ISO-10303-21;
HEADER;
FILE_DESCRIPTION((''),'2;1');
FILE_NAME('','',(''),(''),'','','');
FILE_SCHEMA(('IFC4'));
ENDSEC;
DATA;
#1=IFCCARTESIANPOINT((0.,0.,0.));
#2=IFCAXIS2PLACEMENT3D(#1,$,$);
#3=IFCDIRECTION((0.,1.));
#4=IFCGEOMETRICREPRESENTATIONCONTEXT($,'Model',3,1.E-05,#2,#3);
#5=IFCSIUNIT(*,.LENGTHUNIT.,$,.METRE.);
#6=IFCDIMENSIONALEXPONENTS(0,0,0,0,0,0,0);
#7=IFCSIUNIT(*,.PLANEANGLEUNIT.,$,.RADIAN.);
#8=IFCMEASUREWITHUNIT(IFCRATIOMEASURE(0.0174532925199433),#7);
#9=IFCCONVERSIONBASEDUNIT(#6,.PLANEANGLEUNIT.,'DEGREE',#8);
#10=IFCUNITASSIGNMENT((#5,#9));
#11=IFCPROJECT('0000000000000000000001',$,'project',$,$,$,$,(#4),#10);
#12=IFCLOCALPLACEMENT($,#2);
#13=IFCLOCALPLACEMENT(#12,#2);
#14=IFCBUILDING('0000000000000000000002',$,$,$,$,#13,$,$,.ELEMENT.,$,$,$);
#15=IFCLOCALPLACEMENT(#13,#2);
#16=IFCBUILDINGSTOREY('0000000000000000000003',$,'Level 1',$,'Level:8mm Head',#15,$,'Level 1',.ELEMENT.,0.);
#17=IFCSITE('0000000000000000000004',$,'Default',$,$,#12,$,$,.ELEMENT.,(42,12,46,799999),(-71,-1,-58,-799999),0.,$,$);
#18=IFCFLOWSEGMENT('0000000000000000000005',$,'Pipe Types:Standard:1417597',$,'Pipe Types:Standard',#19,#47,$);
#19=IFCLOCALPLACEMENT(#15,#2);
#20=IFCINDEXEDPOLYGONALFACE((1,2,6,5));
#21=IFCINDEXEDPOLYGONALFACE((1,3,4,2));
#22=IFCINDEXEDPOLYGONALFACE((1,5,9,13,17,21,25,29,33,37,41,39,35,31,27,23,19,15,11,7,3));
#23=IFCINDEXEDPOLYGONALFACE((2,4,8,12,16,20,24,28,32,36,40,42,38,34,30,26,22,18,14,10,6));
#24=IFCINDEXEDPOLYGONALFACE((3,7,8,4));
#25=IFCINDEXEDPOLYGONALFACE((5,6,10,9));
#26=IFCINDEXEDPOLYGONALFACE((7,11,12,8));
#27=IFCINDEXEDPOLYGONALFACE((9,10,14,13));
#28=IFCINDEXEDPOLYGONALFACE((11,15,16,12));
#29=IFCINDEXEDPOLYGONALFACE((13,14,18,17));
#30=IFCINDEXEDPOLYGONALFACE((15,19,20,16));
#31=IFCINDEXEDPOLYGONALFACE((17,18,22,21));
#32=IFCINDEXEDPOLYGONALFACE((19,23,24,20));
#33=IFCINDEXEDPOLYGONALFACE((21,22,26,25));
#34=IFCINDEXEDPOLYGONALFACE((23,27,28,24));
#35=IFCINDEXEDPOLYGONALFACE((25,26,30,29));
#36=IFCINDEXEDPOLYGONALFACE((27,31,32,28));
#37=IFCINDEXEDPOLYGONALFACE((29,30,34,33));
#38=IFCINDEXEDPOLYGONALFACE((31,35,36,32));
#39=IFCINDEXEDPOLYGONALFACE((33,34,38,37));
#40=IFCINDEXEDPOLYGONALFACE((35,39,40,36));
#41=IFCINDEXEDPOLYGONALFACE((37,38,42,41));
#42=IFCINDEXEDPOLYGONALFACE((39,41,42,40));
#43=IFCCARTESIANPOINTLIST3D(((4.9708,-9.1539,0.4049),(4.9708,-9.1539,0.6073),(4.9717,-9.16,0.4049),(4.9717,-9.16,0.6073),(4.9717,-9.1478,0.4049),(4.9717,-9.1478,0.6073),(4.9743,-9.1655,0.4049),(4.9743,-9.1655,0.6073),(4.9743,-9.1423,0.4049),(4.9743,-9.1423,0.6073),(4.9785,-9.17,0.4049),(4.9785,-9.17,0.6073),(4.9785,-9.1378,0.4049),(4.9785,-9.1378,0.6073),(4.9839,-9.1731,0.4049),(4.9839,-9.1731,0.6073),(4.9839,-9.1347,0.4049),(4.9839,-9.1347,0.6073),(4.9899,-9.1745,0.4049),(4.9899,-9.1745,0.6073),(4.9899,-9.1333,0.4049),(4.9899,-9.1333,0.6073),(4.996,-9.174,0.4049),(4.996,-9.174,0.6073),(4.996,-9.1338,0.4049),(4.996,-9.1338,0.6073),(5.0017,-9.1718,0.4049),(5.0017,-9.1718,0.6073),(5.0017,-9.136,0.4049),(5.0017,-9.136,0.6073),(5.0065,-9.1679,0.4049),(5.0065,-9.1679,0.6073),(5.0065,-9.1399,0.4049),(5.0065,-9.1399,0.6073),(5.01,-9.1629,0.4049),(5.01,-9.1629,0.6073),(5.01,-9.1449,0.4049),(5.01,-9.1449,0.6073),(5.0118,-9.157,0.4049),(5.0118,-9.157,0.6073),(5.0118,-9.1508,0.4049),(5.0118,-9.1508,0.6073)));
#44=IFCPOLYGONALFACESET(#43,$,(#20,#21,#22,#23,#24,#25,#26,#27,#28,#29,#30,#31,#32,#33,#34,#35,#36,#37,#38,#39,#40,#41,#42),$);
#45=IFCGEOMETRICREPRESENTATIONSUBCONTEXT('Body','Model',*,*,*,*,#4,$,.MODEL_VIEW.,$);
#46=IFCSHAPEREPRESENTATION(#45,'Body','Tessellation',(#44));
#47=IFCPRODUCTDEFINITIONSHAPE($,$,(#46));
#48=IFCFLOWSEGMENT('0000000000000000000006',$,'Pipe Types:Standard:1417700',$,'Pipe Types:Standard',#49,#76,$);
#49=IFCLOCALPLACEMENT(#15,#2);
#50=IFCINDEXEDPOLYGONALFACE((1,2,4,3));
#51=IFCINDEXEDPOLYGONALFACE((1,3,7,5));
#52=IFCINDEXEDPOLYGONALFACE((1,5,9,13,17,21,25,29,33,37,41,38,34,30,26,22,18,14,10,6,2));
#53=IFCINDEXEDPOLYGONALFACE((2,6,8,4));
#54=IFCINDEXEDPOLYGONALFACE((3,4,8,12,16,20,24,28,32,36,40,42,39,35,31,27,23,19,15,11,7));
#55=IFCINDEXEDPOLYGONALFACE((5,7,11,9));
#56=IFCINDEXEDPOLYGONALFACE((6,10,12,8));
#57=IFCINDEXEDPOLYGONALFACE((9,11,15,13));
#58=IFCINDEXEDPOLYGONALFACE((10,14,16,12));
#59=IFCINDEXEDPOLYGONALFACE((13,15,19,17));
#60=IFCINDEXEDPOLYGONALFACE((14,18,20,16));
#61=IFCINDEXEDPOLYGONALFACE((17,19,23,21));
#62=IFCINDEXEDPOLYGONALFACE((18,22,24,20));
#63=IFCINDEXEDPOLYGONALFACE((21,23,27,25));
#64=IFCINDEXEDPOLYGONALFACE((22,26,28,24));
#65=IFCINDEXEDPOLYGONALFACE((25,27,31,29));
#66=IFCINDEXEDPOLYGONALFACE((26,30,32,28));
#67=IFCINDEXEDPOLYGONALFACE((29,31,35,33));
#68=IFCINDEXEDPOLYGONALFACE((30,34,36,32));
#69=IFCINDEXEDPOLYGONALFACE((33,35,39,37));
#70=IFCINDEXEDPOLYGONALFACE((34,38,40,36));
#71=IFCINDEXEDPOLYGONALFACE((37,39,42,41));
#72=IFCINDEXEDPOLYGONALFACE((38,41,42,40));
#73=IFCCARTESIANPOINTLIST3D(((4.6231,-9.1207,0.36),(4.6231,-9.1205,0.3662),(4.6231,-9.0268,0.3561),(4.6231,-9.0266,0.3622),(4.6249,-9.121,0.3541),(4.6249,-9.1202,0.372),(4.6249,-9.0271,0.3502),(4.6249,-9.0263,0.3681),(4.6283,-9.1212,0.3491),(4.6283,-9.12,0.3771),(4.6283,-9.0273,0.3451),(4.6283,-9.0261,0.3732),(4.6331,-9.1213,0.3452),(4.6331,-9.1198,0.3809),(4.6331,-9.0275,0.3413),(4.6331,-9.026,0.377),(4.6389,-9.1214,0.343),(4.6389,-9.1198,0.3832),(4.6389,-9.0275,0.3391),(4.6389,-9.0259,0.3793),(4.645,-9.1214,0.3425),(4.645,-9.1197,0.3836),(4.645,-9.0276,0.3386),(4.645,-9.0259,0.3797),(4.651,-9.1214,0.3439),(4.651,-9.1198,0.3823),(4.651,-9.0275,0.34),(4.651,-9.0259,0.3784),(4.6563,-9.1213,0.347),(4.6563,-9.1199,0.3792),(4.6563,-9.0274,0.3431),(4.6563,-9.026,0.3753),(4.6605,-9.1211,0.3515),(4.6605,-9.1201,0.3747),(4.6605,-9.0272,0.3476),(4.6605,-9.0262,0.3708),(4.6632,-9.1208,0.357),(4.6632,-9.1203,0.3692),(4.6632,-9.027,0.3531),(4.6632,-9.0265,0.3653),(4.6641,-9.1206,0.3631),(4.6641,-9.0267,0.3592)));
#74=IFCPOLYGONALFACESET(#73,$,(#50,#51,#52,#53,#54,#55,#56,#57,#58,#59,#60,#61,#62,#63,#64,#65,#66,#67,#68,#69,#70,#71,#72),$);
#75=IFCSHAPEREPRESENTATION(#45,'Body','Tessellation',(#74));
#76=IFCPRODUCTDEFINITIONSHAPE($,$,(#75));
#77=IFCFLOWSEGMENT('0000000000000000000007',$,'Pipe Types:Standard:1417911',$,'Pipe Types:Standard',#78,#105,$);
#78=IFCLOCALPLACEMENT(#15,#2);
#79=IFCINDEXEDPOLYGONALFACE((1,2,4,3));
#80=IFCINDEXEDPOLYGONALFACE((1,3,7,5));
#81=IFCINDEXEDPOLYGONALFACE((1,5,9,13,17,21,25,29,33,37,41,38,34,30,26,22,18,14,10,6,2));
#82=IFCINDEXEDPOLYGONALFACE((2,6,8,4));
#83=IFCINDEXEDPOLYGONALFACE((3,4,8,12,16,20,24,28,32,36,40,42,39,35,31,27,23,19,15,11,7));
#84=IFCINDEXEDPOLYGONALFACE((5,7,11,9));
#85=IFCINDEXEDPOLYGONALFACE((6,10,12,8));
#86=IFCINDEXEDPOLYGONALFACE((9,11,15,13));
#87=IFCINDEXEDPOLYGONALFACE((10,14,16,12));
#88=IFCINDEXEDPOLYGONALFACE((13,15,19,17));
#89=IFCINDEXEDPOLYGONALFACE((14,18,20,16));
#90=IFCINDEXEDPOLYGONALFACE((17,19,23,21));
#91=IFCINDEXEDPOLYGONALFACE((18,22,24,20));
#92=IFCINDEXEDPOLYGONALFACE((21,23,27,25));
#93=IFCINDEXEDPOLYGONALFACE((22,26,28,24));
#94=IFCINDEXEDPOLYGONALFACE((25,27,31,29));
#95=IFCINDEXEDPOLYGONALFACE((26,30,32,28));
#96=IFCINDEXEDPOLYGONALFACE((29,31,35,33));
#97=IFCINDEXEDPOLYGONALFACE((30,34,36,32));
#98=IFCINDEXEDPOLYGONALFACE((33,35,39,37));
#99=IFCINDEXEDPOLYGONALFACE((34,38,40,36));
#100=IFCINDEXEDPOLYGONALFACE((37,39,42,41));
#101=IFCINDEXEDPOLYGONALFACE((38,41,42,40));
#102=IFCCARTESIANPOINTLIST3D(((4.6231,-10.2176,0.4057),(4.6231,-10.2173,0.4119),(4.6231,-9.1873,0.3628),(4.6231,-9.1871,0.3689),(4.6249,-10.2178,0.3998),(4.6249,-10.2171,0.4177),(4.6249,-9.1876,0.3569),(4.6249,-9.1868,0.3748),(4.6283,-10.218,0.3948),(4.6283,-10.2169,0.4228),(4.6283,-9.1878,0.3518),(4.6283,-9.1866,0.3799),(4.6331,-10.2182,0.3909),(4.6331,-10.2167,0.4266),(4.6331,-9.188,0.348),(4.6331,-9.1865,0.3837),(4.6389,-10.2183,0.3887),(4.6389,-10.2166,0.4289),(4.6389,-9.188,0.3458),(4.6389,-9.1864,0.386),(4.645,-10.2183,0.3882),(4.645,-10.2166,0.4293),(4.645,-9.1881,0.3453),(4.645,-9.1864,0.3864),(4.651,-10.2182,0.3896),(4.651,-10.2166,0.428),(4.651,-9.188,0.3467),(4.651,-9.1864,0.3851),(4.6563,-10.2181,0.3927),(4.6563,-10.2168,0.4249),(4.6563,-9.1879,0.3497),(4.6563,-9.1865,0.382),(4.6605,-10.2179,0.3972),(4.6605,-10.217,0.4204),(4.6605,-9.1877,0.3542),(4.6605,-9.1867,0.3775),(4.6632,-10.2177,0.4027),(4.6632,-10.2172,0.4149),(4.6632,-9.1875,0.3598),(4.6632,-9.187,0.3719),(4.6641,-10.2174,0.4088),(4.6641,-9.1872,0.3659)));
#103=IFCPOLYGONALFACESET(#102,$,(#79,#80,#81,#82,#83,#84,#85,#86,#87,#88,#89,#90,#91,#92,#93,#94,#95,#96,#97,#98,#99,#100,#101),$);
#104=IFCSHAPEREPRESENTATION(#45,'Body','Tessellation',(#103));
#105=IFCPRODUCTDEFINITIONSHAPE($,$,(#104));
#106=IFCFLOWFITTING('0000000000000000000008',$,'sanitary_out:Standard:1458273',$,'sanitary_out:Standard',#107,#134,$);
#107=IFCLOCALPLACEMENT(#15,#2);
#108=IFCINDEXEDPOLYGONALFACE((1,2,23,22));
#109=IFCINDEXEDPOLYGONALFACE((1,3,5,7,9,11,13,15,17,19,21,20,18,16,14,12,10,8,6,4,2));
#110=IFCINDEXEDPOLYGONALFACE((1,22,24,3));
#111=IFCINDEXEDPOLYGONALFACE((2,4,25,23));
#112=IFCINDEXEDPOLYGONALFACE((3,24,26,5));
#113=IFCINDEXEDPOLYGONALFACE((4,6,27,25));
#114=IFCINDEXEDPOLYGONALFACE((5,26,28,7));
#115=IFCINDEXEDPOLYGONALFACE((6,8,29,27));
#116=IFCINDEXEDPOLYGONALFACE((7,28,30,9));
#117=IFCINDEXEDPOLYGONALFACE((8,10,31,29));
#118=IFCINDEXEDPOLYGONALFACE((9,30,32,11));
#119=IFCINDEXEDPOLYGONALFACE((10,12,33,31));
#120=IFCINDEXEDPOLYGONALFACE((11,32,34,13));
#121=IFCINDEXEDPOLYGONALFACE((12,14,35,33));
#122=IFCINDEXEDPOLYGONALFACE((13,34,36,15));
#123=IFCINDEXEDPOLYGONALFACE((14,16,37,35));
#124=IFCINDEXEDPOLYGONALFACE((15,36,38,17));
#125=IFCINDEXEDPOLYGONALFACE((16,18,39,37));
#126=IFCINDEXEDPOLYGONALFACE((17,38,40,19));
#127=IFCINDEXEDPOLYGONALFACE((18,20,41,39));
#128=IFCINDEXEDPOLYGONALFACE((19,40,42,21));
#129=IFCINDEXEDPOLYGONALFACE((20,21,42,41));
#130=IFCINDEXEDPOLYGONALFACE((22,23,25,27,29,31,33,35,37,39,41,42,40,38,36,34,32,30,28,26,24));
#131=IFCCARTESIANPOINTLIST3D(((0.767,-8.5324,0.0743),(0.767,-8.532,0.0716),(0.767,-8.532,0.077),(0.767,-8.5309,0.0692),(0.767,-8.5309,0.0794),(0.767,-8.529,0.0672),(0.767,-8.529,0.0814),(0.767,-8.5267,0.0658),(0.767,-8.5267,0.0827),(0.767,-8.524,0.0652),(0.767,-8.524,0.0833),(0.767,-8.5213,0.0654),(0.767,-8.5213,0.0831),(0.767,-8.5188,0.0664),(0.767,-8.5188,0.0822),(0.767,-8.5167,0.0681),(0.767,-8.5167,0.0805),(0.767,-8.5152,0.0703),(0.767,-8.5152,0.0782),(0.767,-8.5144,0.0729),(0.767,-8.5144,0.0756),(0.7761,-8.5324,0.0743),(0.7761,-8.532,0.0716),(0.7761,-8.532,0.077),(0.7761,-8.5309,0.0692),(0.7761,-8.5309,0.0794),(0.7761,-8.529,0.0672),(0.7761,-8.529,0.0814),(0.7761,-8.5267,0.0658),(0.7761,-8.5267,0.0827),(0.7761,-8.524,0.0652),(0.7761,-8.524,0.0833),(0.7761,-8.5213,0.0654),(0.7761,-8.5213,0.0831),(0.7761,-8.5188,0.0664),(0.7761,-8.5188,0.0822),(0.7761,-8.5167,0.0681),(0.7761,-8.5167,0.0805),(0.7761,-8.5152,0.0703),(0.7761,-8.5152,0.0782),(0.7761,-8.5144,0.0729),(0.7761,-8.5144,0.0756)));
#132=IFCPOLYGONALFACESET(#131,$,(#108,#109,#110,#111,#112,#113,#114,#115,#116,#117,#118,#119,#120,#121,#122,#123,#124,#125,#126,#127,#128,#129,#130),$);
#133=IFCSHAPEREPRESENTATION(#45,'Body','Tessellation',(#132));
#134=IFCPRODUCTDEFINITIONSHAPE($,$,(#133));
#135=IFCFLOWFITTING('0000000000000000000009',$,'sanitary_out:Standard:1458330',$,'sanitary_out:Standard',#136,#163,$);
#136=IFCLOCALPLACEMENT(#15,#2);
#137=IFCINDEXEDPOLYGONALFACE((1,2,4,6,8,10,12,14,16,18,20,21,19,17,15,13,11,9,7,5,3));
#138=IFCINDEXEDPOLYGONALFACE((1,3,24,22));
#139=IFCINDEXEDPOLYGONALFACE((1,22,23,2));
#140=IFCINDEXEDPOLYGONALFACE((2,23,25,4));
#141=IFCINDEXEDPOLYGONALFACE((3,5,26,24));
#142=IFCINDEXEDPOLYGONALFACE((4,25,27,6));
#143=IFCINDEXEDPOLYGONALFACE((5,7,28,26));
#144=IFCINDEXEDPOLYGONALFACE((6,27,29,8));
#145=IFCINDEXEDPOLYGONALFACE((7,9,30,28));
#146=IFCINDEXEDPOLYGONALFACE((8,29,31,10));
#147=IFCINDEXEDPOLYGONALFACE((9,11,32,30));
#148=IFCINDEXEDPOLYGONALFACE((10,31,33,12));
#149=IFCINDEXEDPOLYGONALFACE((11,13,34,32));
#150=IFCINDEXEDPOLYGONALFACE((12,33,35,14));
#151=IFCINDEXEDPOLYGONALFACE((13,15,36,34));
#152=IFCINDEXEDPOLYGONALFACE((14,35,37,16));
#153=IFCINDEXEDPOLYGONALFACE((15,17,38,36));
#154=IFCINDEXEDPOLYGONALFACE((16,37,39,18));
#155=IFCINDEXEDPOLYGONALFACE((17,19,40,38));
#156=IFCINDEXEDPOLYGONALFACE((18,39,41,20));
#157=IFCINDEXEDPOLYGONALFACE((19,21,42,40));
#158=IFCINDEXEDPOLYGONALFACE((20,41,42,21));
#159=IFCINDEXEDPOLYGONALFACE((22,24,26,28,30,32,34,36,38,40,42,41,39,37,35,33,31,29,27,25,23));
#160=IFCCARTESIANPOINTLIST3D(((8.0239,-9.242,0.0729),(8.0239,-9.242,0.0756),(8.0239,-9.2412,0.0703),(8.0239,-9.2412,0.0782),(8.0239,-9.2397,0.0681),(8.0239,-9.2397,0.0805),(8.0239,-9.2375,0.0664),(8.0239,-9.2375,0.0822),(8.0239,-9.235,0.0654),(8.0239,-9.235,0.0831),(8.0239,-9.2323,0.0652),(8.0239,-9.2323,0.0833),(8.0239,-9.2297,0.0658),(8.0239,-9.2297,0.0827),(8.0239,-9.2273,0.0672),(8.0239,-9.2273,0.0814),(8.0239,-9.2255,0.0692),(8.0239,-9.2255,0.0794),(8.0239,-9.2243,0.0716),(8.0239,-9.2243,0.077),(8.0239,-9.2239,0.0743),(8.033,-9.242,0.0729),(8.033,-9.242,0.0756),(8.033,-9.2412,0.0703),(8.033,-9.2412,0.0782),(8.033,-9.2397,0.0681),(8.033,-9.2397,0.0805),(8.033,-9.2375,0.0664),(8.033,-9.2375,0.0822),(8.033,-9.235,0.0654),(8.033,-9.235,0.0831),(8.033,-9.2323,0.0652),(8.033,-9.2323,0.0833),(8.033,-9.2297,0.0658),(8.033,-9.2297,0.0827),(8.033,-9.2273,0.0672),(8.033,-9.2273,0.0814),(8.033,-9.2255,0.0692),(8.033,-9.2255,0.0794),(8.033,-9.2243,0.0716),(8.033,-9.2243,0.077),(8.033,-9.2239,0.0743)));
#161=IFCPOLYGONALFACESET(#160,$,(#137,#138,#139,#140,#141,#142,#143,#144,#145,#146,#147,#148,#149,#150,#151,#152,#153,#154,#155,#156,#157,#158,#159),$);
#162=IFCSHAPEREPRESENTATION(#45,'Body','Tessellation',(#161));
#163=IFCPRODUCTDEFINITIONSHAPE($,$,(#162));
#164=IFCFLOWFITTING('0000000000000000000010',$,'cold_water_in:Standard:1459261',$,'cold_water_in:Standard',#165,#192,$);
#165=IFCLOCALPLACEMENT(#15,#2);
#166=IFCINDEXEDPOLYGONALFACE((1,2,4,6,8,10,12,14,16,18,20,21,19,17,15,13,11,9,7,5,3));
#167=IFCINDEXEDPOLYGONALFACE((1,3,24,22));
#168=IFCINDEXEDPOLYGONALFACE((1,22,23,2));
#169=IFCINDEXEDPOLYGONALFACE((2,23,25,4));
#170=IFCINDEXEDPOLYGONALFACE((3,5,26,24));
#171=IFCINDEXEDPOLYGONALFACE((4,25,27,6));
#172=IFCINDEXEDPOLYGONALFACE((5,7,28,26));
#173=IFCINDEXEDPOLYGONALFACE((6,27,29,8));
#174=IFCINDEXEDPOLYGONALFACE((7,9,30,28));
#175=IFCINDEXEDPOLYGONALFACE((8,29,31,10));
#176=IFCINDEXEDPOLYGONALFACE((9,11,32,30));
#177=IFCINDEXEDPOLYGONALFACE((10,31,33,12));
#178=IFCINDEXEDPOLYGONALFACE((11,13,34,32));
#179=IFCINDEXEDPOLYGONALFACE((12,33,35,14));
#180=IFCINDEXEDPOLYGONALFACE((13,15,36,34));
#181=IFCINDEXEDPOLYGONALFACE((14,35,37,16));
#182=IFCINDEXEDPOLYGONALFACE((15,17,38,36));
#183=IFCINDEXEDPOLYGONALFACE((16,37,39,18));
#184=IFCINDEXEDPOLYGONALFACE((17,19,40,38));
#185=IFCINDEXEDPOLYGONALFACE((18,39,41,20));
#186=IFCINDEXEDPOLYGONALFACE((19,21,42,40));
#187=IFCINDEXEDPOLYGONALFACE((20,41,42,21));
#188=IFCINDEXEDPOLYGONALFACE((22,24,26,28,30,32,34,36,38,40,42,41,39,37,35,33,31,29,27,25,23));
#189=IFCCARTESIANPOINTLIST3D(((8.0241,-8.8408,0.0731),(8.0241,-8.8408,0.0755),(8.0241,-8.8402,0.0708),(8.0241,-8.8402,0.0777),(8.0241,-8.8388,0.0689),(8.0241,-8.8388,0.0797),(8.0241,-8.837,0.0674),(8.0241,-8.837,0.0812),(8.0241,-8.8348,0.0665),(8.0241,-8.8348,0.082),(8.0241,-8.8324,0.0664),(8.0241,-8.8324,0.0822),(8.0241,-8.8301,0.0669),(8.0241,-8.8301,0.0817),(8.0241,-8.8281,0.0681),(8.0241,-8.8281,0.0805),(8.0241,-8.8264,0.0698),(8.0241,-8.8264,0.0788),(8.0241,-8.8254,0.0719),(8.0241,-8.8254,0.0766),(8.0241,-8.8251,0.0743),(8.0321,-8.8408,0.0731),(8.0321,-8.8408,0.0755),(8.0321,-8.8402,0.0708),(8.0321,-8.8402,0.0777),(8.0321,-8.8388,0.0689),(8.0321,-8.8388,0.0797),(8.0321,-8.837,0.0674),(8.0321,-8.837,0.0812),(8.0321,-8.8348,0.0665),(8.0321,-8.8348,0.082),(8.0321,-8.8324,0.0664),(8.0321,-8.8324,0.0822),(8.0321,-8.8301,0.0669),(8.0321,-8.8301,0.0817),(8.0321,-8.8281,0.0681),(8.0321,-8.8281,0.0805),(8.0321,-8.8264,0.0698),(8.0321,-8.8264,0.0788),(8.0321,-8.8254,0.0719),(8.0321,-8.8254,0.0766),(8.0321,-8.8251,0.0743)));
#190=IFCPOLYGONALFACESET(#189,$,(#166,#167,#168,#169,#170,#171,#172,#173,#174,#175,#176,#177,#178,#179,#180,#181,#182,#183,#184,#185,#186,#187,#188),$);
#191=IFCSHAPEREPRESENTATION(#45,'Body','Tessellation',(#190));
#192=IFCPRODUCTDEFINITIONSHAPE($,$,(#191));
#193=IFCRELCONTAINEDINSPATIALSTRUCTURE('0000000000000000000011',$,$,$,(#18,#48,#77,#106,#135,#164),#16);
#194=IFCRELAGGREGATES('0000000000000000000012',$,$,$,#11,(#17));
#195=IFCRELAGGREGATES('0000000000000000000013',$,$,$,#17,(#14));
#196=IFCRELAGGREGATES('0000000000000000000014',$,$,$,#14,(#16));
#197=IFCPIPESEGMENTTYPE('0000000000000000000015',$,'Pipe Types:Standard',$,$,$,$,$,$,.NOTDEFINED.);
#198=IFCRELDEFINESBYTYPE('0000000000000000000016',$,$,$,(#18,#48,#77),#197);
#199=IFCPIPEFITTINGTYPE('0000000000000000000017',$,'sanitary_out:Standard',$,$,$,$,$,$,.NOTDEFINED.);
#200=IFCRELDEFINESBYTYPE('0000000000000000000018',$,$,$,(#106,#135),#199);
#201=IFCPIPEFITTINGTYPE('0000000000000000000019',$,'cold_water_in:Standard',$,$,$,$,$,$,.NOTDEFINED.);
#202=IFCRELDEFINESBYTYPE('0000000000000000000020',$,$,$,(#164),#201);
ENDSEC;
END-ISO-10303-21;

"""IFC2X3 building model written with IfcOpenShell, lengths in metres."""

from ifc_helpers import new_model, entity, si_unit, converted_unit, direction, frame, frame_2d, origin, origin_2d_with_axis, place, context, subcontext, project, spatial, circle, extrude, source, transform, mapped, type_object, type_shapes, element, save


model = new_model("IFC2X3")

# Units and contexts
model_context = context("Model", 3, precision=1e-05, world=origin(), true_north=direction((0.0, 1.0)))
body_context = subcontext(model_context, "Body", "Model", "MODEL_VIEW")
ifc_project = project(units=[si_unit("LENGTHUNIT", "METRE"), converted_unit("PLANEANGLEUNIT", "DEGREE", entity("IfcRatioMeasure", 0.0174532925199433), si_unit("PLANEANGLEUNIT", "RADIAN"), dimensions=[0, 0, 0, 0, 0, 0, 0])], contexts=[model_context])

# Site, building, storey
site_placement = place(None, origin())
site = spatial("IfcSite", under=ifc_project, at=site_placement, Name="Default", CompositionType="ELEMENT", RefLatitude=(42, 12, 46, 799999), RefLongitude=(-71, -1, -58, -799999), RefElevation=0.0)
building_placement = place(site_placement, origin())
building = spatial("IfcBuilding", under=site, at=building_placement, CompositionType="ELEMENT")
storey_placement = place(building_placement, origin())
storey = spatial("IfcBuildingStorey", under=building, at=storey_placement, Name="Level 1", ObjectType="Level:8mm Head", LongName="Level 1", CompositionType="ELEMENT", Elevation=0.0)

# Flow segments
pipe_segment_type = type_object("IfcPipeSegmentType", Name="Pipe Types:Standard", PredefinedType="NOTDEFINED")
flow_segment_1_placement = place(storey_placement, origin())
element("IfcFlowSegment", 1, at=flow_segment_1_placement, inside=storey, type_object=pipe_segment_type, Name="Pipe Types:Standard:1417597", ObjectType="Pipe Types:Standard", context=body_context, shape_type="SweptSolid", body=[
    extrude(circle(Radius=0.0206, at=origin_2d_with_axis()), frame((4.9914, -9.1539, 0.4049), z_axis=(0.0, 0.0, 1.0), x_axis=(-1.0, 0.0, 0.0)), (0.0, 0.0, 1.0), 0.2024),
])
flow_segment_2_placement = place(storey_placement, origin())
element("IfcFlowSegment", 2, at=flow_segment_2_placement, inside=storey, type_object=pipe_segment_type, Name="Pipe Types:Standard:1417700", ObjectType="Pipe Types:Standard", context=body_context, shape_type="SweptSolid", body=[
    extrude(circle(Radius=0.0206, at=frame_2d((0.0, 0.0), x_axis=(1.0, 0.0))), frame((4.6435, -9.0267, 0.3592), z_axis=(0.0, -0.999133, 0.041631), x_axis=(1.0, 0.0, 0.0)), (0.0, 0.0, 1.0), 0.094),
])
flow_segment_3_placement = place(storey_placement, origin())
element("IfcFlowSegment", 3, at=flow_segment_3_placement, inside=storey, type_object=pipe_segment_type, Name="Pipe Types:Standard:1417911", ObjectType="Pipe Types:Standard", context=body_context, shape_type="SweptSolid", body=[
    extrude(circle(Radius=0.0206, at=frame_2d((0.0, 0.0), x_axis=(1.0, 0.0))), frame((4.6435, -10.2174, 0.4088), z_axis=(0.0, 0.999133, -0.041631), x_axis=(1.0, 0.0, 0.0)), (0.0, 0.0, 1.0), 1.0311),
])

# Flow fittings
pipe_fitting_type_1 = type_object("IfcPipeFittingType", Name="sanitary_out:Standard", PredefinedType="NOTDEFINED")
shared_shape_1 = source(origin(), body_context, "Body", "SweptSolid", [
    extrude(circle(Radius=0.0091, at=frame_2d((0.0, 0.0), x_axis=(1.0, 0.0))), frame((0.0, 0.0, 0.0), z_axis=(1.0, 0.0, 0.0), x_axis=(0.0, 1.0, 0.0)), (0.0, 0.0, 1.0), 0.0091),
])
type_shapes(pipe_fitting_type_1, [shared_shape_1])
flow_fitting_1_placement = place(storey_placement, frame((0.7761, -8.5234, 0.0743), z_axis=(0.0, 0.0, 1.0), x_axis=(-1.0, 0.0, 0.0)))
element("IfcFlowFitting", 4, at=flow_fitting_1_placement, inside=storey, type_object=pipe_fitting_type_1, Name="sanitary_out:Standard:1458273", ObjectType="sanitary_out:Standard", context=body_context, shape_type="MappedRepresentation", body=[
    mapped(shared_shape_1, transform((0.0, 0.0, 0.0), scale=1.0)),
])
flow_fitting_2_placement = place(storey_placement, frame((8.0239, -9.233, 0.0743)))
element("IfcFlowFitting", 5, at=flow_fitting_2_placement, inside=storey, type_object=pipe_fitting_type_1, Name="sanitary_out:Standard:1458330", ObjectType="sanitary_out:Standard", context=body_context, shape_type="MappedRepresentation", body=[
    mapped(shared_shape_1, transform((0.0, 0.0, 0.0), scale=1.0)),
])
pipe_fitting_type_2 = type_object("IfcPipeFittingType", Name="cold_water_in:Standard", PredefinedType="NOTDEFINED")
shared_shape_2 = source(origin(), body_context, "Body", "SweptSolid", [
    extrude(circle(Radius=0.0079, at=frame_2d((0.0, 0.0), x_axis=(1.0, 0.0))), frame((0.0, 0.0, 0.0), z_axis=(1.0, 0.0, 0.0), x_axis=(0.0, 1.0, 0.0)), (0.0, 0.0, 1.0), 0.0079),
])
type_shapes(pipe_fitting_type_2, [shared_shape_2])
flow_fitting_3_placement = place(storey_placement, frame((8.0241, -8.833, 0.0743), z_axis=(0.000149, 0.0, 1.0), x_axis=(1.0, 0.0, -0.000149)))
element("IfcFlowFitting", 6, at=flow_fitting_3_placement, inside=storey, type_object=pipe_fitting_type_2, Name="cold_water_in:Standard:1459261", ObjectType="cold_water_in:Standard", context=body_context, shape_type="MappedRepresentation", body=[
    mapped(shared_shape_2, transform((0.0, 0.0, 0.0), scale=1.0)),
])

save(model, "model.ifc")
